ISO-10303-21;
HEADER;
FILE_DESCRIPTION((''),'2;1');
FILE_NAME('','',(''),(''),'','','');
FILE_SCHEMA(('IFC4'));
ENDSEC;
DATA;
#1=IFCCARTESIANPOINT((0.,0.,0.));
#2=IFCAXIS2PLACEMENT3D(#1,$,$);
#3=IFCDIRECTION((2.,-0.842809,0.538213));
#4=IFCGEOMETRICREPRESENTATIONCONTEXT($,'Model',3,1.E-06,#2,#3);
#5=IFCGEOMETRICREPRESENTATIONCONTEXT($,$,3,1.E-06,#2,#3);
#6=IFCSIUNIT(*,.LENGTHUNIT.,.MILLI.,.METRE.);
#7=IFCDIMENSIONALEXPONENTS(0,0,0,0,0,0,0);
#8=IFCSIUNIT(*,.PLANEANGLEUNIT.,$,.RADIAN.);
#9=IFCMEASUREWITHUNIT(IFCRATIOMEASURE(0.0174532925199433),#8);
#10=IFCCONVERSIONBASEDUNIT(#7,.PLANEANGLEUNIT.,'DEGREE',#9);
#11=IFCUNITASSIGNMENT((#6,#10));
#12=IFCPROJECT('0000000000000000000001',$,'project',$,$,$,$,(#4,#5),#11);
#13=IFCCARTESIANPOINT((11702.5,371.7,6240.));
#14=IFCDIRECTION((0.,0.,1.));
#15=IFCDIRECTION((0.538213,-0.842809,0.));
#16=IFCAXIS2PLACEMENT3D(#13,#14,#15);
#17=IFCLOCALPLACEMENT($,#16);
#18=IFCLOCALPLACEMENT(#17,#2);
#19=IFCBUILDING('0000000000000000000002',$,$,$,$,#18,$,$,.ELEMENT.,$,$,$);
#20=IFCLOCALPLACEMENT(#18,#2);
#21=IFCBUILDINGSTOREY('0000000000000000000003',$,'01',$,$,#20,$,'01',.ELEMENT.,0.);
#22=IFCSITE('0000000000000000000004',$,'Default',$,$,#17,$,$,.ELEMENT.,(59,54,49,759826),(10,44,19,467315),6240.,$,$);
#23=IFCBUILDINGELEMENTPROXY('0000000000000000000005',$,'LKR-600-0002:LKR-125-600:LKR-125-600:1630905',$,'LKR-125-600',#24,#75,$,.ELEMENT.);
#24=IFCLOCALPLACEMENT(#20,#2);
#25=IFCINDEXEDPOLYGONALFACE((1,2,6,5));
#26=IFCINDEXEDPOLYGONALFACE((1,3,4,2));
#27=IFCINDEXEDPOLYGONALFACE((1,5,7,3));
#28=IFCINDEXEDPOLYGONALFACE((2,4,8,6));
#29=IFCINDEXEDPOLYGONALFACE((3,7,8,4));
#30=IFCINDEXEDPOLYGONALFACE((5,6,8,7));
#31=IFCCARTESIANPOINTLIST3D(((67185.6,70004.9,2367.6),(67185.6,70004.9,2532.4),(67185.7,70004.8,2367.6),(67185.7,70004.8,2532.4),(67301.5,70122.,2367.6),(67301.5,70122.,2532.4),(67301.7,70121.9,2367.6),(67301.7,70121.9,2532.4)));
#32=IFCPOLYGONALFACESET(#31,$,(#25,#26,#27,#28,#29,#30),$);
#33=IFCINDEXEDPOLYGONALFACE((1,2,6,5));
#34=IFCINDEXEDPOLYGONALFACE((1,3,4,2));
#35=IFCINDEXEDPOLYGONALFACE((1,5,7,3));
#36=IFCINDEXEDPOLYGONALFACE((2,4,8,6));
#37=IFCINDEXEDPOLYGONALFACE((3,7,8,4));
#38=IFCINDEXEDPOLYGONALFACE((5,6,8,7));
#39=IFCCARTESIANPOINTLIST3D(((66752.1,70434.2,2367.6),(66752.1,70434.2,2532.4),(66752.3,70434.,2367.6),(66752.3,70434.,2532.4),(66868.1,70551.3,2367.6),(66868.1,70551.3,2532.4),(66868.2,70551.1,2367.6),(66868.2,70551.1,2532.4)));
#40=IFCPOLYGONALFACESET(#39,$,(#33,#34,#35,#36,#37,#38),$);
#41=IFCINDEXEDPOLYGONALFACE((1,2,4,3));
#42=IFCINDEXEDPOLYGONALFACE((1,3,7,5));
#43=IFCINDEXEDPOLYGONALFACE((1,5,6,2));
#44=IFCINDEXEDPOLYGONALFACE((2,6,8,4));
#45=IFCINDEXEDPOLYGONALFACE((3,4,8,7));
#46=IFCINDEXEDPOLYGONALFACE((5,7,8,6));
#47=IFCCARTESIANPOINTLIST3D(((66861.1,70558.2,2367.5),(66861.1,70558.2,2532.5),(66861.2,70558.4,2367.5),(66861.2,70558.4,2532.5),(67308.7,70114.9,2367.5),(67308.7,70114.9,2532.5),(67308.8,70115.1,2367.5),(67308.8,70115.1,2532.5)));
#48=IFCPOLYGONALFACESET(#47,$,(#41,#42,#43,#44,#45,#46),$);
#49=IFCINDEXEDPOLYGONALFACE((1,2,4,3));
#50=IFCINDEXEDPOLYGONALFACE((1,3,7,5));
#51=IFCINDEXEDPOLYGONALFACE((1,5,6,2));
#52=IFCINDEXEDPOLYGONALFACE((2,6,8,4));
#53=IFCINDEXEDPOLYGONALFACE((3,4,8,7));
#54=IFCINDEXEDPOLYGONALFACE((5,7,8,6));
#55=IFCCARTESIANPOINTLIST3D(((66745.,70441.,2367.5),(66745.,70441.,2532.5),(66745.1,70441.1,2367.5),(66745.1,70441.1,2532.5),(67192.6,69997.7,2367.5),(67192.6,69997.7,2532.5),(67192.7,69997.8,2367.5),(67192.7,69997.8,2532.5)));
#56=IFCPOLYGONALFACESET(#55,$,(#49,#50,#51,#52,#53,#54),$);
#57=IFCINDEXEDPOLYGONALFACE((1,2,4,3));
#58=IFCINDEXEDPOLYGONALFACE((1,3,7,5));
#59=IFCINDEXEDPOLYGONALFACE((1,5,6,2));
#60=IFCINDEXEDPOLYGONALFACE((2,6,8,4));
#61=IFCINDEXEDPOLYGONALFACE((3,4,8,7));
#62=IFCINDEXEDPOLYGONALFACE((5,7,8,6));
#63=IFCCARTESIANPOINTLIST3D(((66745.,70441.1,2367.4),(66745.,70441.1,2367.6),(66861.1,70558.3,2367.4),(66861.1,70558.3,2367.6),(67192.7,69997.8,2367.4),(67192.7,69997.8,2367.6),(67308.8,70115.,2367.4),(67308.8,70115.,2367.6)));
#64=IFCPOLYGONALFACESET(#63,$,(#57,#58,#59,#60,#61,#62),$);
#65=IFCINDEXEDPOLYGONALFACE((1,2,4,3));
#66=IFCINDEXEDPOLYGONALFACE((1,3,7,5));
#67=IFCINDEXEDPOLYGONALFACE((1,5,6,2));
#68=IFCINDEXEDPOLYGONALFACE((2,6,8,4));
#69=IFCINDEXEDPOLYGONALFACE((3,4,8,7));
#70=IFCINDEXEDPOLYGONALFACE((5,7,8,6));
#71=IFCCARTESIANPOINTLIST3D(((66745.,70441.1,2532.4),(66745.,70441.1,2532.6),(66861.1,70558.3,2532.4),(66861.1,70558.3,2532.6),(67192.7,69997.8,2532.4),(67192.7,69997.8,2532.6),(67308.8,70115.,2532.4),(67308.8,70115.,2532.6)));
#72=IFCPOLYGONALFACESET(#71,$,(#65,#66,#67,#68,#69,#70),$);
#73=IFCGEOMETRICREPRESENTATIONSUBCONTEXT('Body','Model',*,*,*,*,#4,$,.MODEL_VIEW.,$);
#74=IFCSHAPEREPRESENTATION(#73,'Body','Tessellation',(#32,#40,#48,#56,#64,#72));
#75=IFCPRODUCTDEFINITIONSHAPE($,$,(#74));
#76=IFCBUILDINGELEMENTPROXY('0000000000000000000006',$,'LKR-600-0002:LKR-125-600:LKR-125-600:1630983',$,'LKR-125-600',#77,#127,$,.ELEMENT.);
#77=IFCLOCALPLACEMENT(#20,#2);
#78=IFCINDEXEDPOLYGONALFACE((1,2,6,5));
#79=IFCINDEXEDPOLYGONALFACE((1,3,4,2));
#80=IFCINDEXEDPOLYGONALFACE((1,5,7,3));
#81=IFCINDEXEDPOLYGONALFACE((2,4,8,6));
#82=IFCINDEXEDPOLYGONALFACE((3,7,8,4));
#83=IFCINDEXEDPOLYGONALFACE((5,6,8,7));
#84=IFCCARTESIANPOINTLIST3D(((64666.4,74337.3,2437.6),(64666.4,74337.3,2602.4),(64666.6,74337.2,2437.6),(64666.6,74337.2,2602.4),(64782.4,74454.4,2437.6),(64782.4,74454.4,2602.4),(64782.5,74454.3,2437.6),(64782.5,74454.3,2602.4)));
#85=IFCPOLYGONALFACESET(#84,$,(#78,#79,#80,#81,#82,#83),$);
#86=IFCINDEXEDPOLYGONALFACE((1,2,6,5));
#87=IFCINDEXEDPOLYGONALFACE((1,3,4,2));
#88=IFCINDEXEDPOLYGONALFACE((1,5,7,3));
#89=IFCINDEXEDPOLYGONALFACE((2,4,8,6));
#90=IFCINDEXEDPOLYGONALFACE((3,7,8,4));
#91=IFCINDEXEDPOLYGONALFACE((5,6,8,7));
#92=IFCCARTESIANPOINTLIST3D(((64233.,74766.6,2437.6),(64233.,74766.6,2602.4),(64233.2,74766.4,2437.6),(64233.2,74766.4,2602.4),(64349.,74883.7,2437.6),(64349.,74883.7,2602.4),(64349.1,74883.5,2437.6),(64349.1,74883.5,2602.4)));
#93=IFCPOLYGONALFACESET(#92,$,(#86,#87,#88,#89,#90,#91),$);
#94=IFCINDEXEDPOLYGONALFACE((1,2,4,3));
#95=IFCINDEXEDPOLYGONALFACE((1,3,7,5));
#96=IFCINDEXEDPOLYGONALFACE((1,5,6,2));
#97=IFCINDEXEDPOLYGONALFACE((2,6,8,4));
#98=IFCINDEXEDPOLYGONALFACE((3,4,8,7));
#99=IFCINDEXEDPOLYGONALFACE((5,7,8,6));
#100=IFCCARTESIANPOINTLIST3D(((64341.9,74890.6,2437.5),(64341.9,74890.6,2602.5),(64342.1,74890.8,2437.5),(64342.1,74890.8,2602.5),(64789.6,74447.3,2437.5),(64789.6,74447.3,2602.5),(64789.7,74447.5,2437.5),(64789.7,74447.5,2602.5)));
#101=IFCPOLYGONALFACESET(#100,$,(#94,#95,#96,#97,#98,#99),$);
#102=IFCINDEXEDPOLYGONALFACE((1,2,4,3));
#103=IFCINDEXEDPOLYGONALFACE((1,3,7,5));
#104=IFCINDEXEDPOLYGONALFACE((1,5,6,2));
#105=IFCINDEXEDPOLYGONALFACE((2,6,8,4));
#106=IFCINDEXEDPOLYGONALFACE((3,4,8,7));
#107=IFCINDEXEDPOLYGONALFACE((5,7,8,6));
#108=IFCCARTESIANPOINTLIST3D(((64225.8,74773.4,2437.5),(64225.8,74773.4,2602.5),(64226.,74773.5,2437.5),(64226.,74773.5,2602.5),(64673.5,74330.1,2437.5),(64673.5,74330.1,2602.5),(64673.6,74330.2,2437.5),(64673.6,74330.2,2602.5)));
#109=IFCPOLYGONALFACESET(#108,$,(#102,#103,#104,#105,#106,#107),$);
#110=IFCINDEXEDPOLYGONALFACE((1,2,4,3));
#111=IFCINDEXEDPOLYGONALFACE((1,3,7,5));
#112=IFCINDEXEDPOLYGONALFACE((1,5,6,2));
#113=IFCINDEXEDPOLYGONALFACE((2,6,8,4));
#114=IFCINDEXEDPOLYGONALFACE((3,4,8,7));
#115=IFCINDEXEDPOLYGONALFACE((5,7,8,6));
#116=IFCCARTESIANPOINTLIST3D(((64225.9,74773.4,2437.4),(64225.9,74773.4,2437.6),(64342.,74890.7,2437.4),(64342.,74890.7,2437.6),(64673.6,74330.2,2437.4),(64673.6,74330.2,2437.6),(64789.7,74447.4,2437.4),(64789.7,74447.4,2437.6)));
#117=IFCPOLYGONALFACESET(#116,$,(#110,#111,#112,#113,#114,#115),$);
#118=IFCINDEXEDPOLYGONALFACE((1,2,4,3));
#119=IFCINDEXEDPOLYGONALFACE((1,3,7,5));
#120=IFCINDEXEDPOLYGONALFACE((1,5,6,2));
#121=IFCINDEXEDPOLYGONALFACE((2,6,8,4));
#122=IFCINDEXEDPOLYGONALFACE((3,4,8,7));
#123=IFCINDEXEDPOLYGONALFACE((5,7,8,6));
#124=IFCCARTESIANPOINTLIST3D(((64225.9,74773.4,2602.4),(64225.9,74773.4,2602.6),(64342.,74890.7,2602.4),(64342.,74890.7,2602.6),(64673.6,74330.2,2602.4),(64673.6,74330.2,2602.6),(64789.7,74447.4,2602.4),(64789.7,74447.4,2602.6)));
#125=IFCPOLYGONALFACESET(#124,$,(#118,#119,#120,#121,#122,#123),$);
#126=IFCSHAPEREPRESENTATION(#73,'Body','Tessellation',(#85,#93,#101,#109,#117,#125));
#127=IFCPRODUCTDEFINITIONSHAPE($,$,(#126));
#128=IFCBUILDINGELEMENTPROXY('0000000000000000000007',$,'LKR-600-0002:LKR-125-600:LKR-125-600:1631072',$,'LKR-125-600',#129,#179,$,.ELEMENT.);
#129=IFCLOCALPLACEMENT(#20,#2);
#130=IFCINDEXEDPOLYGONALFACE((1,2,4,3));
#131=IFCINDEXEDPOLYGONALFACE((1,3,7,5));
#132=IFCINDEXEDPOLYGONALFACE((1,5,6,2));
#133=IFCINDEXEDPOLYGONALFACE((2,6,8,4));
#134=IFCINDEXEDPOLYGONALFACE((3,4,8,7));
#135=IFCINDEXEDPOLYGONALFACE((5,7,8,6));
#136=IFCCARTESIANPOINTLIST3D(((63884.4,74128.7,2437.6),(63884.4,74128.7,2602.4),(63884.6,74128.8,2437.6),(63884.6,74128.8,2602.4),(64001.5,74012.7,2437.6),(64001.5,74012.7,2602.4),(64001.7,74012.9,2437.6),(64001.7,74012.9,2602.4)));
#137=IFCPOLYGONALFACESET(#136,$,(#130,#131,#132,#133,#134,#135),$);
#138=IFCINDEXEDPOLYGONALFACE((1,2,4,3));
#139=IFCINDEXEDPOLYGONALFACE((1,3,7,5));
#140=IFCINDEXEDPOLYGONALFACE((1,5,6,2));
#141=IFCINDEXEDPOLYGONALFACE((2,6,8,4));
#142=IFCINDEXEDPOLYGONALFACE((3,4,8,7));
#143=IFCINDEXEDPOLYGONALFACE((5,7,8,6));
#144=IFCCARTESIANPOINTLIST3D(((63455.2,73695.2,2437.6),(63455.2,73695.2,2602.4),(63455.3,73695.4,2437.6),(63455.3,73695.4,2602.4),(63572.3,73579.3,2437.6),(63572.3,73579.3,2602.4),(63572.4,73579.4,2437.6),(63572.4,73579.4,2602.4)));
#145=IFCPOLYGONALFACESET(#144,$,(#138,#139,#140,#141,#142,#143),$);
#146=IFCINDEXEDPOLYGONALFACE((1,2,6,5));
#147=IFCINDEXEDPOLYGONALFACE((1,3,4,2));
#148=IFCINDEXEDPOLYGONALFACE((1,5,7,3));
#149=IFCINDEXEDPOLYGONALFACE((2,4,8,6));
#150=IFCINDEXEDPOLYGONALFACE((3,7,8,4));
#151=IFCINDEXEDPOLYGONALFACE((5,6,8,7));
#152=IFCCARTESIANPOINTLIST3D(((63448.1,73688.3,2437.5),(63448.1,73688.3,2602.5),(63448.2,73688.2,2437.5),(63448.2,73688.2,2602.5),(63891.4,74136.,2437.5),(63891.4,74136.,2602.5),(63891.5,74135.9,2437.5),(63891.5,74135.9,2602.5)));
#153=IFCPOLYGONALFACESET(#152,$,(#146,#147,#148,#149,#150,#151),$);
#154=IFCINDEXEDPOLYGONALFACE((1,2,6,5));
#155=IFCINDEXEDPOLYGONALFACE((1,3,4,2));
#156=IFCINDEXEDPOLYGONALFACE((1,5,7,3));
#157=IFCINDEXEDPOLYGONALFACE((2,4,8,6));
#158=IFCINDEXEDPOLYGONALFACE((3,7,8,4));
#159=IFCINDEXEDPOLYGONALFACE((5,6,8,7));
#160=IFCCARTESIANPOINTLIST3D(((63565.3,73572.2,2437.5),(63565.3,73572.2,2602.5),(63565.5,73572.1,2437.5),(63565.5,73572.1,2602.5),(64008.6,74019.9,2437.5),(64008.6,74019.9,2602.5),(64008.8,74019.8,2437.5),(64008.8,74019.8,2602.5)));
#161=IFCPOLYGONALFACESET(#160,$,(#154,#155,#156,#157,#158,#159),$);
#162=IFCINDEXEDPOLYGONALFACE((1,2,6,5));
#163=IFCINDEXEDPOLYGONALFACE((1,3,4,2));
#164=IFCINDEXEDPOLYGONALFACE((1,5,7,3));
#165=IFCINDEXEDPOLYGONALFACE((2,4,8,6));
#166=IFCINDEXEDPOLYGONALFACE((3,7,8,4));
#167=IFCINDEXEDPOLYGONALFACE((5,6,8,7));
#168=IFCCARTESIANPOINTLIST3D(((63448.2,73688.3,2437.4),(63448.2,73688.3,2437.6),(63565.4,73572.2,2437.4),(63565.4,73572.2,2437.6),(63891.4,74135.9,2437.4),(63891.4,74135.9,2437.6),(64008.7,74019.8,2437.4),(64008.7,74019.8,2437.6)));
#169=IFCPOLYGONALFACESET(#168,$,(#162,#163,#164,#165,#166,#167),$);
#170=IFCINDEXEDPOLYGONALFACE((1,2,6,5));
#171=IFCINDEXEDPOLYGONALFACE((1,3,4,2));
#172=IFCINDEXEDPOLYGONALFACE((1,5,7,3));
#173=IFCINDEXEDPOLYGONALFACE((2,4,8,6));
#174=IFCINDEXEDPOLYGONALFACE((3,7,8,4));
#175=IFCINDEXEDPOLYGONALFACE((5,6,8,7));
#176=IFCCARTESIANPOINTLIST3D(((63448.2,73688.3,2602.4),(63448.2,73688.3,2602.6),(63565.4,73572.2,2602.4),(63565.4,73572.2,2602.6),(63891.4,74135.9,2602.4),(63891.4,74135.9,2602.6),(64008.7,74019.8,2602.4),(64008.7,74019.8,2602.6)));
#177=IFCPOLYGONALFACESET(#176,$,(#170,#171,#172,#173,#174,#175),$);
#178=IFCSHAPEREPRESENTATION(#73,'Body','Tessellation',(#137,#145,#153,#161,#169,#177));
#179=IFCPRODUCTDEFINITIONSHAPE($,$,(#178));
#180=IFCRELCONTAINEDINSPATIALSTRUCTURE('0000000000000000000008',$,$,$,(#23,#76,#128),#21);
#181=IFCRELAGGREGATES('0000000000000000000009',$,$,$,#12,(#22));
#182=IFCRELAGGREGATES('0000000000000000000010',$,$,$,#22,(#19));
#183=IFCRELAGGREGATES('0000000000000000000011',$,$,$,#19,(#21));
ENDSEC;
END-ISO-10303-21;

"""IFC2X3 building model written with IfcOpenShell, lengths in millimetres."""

from ifc_helpers import new_model, entity, si_unit, converted_unit, direction, frame, frame_2d, origin, place, context, subcontext, project, spatial, rectangle, extrude, source, transform, mapped, element, save


model = new_model("IFC2X3")

# Units and contexts
model_context = context("Model", 3, precision=1e-06, world=origin(), true_north=direction((2.0, -0.842809, 0.538213)))
context_of_model = context(None, 3, precision=1e-06, world=origin(), true_north=direction((2.0, -0.842809, 0.538213)))
body_context = subcontext(model_context, "Body", "Model", "MODEL_VIEW")
ifc_project = project(units=[si_unit("LENGTHUNIT", "METRE", prefix="MILLI"), converted_unit("PLANEANGLEUNIT", "DEGREE", entity("IfcRatioMeasure", 0.0174532925199433), si_unit("PLANEANGLEUNIT", "RADIAN"), dimensions=[0, 0, 0, 0, 0, 0, 0])], contexts=[model_context, context_of_model])

# Site, building, storey
site_placement = place(None, frame((11702.5, 371.7, 6240.0), z_axis=(0.0, 0.0, 1.0), x_axis=(0.538213, -0.842809, 0.0)))
site = spatial("IfcSite", under=ifc_project, at=site_placement, Name="Default", CompositionType="ELEMENT", RefLatitude=(59, 54, 49, 759826), RefLongitude=(10, 44, 19, 467315), RefElevation=6240.0)
building_placement = place(site_placement, origin())
building = spatial("IfcBuilding", under=site, at=building_placement, CompositionType="ELEMENT")
storey_placement = place(building_placement, origin())
storey = spatial("IfcBuildingStorey", under=building, at=storey_placement, Name="01", LongName="01", CompositionType="ELEMENT", Elevation=0.0)

# Building element proxies
shared_shape_1 = source(origin(), body_context, "Body", "SweptSolid", [
    extrude(rectangle(XDim=0.2, YDim=164.8, at=frame_2d((0.0, 0.0), x_axis=(1.0, 0.0))), frame((305.0, 0.0, -82.4)), (0.0, 0.0, 1.0), 164.8),
    extrude(rectangle(XDim=0.2, YDim=164.8, at=frame_2d((0.0, 0.0), x_axis=(1.0, 0.0))), frame((-305.0, 0.0, -82.4)), (0.0, 0.0, 1.0), 164.8),
    extrude(rectangle(XDim=0.2, YDim=630.0, at=frame_2d((0.0, 0.0), x_axis=(1.0, 0.0))), frame((0.0, 82.5, -82.5), z_axis=(0.0, 0.0, 1.0), x_axis=(0.0, 1.0, 0.0)), (0.0, 0.0, 1.0), 165.0),
    extrude(rectangle(XDim=0.2, YDim=630.0, at=frame_2d((0.0, 0.0), x_axis=(1.0, 0.0))), frame((0.0, -82.5, -82.5), z_axis=(0.0, 0.0, 1.0), x_axis=(0.0, 1.0, 0.0)), (0.0, 0.0, 1.0), 165.0),
    extrude(rectangle(XDim=165.0, YDim=630.0, at=frame_2d((0.0, 0.0), x_axis=(1.0, 0.0))), frame((0.0, 0.0, -82.6), z_axis=(0.0, 0.0, 1.0), x_axis=(0.0, -1.0, 0.0)), (0.0, 0.0, 1.0), 0.2),
    extrude(rectangle(XDim=165.0, YDim=630.0, at=frame_2d((0.0, 0.0), x_axis=(1.0, 0.0))), frame((0.0, 0.0, 82.4), z_axis=(0.0, 0.0, 1.0), x_axis=(0.0, -1.0, 0.0)), (0.0, 0.0, 1.0), 0.2),
])
for number, where, z_axis, x_axis, name in (
    (1, (67026.9, 70278.0, 2450.0), (0.0, 0.0, 1.0), (0.710554, -0.703643, 0.0), "LKR-600-0002:LKR-125-600:LKR-125-600:1630905"),
    (2, (64507.8, 74610.4, 2520.0), (0.0, 0.0, 1.0), (0.710554, -0.703643, 0.0), "LKR-600-0002:LKR-125-600:LKR-125-600:1630983"),
    (3, (63728.4, 73854.1, 2520.0), (0.0, 0.0, 1.0), (0.703643, 0.710554, 0.0), "LKR-600-0002:LKR-125-600:LKR-125-600:1631072"),
):
    element("IfcBuildingElementProxy", number, at=place(storey_placement, frame(where, z_axis=z_axis, x_axis=x_axis)), inside=storey, Name=name, ObjectType="LKR-125-600", CompositionType="ELEMENT", context=body_context, shape_type="MappedRepresentation", body=[
        mapped(shared_shape_1, transform((0.0, 0.0, 0.0), scale=1.0)),
    ])

save(model, "model.ifc")
